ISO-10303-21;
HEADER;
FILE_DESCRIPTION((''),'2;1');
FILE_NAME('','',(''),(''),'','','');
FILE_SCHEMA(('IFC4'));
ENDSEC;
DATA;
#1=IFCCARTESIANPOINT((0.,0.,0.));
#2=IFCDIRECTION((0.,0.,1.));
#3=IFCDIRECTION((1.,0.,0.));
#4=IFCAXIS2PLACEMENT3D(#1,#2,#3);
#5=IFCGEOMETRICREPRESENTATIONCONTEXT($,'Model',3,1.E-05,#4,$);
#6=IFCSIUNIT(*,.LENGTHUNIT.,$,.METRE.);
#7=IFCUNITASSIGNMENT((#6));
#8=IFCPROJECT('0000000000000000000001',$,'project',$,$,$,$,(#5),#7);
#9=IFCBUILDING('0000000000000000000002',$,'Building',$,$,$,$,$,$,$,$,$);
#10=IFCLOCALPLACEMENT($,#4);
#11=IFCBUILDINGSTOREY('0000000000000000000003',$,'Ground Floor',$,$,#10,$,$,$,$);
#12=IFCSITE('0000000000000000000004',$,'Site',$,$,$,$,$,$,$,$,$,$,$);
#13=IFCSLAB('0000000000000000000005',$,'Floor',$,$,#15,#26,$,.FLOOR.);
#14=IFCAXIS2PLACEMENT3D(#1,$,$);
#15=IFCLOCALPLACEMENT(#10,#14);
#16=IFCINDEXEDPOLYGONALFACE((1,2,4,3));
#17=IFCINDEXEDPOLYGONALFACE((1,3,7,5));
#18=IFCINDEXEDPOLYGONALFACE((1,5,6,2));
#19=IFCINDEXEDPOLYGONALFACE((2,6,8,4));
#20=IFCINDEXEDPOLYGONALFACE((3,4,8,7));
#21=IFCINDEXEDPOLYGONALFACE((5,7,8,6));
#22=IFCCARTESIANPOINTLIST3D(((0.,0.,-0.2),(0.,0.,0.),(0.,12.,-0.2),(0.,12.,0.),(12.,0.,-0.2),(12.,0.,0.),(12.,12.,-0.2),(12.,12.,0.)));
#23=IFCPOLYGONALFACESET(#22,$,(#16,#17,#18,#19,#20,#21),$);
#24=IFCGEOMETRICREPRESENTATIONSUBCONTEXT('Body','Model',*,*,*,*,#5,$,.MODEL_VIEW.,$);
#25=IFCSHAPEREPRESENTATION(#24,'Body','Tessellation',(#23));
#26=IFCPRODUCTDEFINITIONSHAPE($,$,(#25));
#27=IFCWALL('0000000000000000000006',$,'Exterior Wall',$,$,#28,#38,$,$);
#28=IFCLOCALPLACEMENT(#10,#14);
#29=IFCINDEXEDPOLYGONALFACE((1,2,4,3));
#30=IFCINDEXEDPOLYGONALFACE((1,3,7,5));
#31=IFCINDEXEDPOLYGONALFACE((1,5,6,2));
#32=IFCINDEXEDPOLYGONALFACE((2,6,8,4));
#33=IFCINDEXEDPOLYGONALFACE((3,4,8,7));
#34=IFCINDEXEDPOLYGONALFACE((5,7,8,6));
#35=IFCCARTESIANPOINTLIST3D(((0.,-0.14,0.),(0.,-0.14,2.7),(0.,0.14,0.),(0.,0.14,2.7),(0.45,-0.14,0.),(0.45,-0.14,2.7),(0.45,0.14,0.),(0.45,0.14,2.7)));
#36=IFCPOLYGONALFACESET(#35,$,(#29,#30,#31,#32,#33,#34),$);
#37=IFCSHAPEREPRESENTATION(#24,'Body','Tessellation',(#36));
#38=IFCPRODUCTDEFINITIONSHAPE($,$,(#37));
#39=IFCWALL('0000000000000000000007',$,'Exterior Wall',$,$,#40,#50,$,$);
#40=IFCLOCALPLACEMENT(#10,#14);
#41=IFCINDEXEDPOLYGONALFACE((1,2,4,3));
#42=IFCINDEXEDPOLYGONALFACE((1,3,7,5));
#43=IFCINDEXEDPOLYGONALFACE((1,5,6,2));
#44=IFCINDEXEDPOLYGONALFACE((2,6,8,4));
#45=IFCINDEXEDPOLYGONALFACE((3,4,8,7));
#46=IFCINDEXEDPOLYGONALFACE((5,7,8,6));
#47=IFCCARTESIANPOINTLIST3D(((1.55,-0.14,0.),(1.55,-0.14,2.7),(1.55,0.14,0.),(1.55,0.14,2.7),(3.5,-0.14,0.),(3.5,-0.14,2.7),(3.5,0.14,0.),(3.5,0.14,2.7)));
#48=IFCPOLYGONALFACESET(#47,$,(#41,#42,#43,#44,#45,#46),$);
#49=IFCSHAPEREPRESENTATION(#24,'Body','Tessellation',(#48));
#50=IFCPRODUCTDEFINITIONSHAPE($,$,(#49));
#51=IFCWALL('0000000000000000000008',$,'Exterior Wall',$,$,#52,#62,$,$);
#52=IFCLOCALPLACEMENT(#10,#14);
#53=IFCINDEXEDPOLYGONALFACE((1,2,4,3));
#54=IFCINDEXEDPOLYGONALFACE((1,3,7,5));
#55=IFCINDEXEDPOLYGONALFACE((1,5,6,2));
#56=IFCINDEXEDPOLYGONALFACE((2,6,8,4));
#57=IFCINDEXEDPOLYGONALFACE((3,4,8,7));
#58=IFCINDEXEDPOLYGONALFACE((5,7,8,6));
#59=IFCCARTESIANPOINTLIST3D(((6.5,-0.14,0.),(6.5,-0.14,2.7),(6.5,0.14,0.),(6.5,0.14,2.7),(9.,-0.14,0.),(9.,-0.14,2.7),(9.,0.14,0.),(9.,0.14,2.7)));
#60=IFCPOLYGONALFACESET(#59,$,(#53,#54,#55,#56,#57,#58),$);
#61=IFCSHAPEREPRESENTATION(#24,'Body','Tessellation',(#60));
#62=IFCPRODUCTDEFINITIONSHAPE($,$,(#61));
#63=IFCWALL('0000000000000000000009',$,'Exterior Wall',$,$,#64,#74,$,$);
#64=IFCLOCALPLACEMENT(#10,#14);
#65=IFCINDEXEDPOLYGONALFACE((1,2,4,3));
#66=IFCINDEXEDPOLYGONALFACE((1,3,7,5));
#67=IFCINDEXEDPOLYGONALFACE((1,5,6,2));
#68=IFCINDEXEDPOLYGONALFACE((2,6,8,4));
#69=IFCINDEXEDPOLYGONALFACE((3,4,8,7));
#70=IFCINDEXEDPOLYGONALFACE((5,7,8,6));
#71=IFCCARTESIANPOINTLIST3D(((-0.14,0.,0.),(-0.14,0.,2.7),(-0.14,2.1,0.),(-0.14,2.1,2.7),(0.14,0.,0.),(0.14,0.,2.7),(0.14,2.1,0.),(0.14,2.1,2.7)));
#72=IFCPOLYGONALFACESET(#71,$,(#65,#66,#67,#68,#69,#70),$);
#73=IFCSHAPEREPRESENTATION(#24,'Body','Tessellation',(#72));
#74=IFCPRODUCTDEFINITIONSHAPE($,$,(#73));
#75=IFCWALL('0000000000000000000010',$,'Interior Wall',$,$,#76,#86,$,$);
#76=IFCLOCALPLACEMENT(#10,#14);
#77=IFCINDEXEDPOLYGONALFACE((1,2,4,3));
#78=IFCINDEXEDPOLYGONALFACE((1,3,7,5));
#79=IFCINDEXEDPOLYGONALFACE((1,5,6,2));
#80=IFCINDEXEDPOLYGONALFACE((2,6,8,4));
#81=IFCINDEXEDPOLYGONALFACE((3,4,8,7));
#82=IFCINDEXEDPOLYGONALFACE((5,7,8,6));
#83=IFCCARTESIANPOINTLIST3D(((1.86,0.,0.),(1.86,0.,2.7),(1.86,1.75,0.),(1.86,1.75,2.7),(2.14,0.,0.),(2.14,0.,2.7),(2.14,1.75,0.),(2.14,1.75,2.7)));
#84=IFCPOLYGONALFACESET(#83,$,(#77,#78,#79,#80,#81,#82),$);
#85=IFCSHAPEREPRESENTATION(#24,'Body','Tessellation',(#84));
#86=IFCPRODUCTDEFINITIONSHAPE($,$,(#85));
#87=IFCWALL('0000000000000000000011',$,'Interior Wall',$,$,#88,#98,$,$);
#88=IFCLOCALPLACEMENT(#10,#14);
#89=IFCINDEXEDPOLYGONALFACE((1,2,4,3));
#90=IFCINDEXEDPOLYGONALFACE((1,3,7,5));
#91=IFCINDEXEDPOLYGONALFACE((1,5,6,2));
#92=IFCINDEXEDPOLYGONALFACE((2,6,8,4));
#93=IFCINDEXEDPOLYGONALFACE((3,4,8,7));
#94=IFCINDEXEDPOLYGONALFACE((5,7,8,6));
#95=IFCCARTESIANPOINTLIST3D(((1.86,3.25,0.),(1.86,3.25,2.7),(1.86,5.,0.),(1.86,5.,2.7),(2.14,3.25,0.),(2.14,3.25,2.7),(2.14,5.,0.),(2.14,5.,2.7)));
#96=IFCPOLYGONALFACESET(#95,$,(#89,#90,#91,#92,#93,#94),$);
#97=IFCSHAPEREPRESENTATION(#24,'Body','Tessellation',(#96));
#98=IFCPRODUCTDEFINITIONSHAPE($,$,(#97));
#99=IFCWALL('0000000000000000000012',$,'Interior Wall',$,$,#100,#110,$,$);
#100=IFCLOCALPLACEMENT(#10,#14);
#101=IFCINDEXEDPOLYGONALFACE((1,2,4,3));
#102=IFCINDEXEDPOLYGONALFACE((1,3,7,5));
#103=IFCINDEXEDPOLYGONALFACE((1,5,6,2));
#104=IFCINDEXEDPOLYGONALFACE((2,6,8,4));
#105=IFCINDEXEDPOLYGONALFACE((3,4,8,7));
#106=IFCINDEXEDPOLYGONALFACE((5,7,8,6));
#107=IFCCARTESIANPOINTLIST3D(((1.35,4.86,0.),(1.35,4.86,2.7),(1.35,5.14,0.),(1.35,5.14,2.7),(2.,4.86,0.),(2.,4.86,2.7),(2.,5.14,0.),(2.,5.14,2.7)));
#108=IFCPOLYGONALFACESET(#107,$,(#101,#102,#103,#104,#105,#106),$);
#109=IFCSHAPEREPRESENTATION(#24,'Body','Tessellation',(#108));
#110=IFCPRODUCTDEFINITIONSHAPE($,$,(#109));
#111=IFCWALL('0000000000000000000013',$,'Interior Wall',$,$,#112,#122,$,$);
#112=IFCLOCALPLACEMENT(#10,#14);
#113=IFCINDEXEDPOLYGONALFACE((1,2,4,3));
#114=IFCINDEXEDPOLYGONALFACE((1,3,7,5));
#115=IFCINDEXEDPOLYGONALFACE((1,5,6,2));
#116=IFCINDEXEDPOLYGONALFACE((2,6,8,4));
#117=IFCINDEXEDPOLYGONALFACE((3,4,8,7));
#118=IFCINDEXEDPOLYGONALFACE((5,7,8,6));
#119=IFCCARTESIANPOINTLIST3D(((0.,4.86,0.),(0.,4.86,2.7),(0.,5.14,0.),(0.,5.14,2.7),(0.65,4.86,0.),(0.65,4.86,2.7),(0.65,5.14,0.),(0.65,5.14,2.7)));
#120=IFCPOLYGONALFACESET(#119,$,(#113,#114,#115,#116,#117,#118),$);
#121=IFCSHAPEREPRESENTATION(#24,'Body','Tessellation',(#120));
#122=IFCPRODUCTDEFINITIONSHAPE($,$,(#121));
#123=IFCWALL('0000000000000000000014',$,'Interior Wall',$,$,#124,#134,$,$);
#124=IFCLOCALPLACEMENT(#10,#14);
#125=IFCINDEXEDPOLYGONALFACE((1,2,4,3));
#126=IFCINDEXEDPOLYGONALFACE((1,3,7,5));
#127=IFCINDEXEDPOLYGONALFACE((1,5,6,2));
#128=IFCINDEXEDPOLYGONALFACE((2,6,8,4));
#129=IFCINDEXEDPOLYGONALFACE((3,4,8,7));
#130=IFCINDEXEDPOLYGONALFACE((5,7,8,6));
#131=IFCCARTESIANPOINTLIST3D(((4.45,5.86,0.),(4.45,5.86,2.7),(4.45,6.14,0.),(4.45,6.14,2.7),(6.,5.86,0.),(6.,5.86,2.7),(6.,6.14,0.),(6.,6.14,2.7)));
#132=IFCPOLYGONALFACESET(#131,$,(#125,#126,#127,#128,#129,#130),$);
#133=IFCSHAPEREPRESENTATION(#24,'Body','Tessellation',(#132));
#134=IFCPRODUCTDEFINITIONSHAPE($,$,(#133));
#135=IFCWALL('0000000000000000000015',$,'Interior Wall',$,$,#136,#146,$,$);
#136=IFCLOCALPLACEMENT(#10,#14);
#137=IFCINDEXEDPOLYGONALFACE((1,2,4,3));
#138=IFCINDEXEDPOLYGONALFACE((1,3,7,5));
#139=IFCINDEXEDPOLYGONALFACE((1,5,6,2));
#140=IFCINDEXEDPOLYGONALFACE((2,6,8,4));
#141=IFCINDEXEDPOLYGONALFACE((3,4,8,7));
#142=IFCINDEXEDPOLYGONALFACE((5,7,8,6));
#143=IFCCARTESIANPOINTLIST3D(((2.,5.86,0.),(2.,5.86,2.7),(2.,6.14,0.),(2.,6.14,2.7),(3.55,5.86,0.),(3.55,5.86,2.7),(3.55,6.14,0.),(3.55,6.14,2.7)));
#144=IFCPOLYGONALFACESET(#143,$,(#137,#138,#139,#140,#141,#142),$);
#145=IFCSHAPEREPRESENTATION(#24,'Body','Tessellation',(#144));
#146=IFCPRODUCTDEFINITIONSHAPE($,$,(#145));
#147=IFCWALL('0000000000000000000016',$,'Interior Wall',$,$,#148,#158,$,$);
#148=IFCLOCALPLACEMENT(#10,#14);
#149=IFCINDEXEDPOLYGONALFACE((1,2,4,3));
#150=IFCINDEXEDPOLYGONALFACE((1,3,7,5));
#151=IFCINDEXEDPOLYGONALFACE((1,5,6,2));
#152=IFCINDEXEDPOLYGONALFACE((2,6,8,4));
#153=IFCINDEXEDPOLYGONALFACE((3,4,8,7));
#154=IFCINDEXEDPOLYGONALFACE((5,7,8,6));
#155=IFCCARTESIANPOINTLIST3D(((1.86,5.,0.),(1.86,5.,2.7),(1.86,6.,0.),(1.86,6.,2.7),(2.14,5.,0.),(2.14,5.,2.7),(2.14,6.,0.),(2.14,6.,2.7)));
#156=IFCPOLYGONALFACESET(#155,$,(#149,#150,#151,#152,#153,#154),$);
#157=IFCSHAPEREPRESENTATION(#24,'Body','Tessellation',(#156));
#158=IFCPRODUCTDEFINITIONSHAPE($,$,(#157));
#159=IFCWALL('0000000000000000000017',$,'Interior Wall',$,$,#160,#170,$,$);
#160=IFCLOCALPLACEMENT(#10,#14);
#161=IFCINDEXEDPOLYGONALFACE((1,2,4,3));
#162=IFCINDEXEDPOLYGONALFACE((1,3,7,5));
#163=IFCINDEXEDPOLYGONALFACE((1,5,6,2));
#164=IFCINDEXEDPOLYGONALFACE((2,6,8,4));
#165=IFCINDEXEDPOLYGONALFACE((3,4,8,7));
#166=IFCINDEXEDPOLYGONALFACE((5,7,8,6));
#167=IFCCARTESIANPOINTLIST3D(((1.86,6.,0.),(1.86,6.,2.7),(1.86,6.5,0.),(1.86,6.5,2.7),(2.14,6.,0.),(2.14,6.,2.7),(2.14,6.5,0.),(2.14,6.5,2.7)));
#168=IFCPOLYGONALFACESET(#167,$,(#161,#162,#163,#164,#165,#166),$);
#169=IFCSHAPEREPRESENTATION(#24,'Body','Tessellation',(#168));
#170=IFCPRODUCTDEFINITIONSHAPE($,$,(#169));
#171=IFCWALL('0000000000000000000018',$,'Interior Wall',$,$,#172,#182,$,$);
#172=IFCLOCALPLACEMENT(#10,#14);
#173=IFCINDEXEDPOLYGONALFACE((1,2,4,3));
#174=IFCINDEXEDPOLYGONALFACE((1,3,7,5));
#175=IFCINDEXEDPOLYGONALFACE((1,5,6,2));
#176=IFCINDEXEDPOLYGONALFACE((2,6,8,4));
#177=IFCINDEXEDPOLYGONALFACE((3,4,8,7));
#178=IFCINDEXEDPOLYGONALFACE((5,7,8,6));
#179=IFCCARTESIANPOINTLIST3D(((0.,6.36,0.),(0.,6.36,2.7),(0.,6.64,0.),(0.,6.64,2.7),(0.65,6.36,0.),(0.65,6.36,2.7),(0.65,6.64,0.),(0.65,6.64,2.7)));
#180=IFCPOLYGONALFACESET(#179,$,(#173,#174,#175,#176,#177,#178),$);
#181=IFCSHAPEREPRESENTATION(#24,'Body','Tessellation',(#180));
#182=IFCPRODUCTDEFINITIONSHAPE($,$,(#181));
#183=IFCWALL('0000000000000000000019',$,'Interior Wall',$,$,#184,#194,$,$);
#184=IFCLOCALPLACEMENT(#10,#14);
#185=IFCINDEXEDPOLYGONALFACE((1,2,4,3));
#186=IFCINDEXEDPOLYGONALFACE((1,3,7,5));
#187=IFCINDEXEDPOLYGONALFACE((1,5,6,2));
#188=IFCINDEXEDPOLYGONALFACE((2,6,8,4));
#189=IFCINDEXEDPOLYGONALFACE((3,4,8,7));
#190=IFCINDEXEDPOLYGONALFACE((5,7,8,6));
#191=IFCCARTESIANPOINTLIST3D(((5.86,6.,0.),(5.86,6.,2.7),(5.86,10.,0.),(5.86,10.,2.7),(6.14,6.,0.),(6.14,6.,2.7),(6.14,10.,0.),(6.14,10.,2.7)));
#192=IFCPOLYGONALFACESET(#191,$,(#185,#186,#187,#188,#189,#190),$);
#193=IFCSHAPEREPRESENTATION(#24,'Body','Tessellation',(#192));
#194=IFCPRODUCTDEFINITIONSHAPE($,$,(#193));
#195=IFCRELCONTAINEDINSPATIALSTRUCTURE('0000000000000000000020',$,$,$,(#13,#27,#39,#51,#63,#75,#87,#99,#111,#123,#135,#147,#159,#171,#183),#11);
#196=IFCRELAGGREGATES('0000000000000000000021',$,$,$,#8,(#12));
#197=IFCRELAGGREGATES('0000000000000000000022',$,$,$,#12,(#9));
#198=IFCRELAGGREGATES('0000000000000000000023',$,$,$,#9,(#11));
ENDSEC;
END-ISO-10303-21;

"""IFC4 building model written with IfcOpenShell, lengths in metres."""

from ifc_helpers import new_model, si_unit, frame, origin_with_axes, place, context, subcontext, project, spatial, indexed_curve, outline, extrude, element, save


model = new_model("IFC4")

# Units and contexts
model_context = context("Model", 3, precision=1e-05, world=origin_with_axes())
body_context = subcontext(model_context, "Body", "Model", "MODEL_VIEW")
ifc_project = project(units=[si_unit("LENGTHUNIT", "METRE")], contexts=[model_context])

# Site, building, storey
site = spatial("IfcSite", under=ifc_project, Name="Site")
building = spatial("IfcBuilding", under=site, Name="Building")
storey_placement = place(None, origin_with_axes())
storey = spatial("IfcBuildingStorey", under=building, at=storey_placement, Name="Ground Floor")

# Slab
slab_placement = place(storey_placement, frame((0.0, 0.0, -0.2), z_axis=(0.0, 0.0, 1.0), x_axis=(1.0, 0.0, 0.0)))
element("IfcSlab", 1, at=slab_placement, inside=storey, Name="Floor", PredefinedType="FLOOR", context=body_context, shape_type="SweptSolid", body=[
    extrude(outline(indexed_curve([(0.0, 0.0), (12.0, 0.0), (12.0, 12.0), (0.0, 12.0)])), None, (0.0, 0.0, 1.0), 0.2),
])

# Walls
wall_1_placement = place(storey_placement, origin_with_axes())
element("IfcWall", 2, at=wall_1_placement, inside=storey, Name="Exterior Wall", context=body_context, shape_type="SweptSolid", body=[
    extrude(outline(indexed_curve([(0.0, 0.0), (0.0, 0.28), (0.45, 0.28), (0.45, 0.0), (0.0, 0.0)], self_intersect=False)), frame((0.0, -0.14, 0.0), z_axis=(0.0, 0.0, 1.0), x_axis=(1.0, 0.0, 0.0)), (0.0, 0.0, 1.0), 2.7),
])
wall_2_placement = place(storey_placement, frame((1.55, 0.0, 0.0), z_axis=(0.0, 0.0, 1.0), x_axis=(1.0, 0.0, 0.0)))
element("IfcWall", 3, at=wall_2_placement, inside=storey, Name="Exterior Wall", context=body_context, shape_type="SweptSolid", body=[
    extrude(outline(indexed_curve([(0.0, 0.0), (0.0, 0.28), (1.95, 0.28), (1.95, 0.0), (0.0, 0.0)], self_intersect=False)), frame((0.0, -0.14, 0.0), z_axis=(0.0, 0.0, 1.0), x_axis=(1.0, 0.0, 0.0)), (0.0, 0.0, 1.0), 2.7),
])
wall_3_placement = place(storey_placement, frame((6.5, 0.0, 0.0), z_axis=(0.0, 0.0, 1.0), x_axis=(1.0, 0.0, 0.0)))
element("IfcWall", 4, at=wall_3_placement, inside=storey, Name="Exterior Wall", context=body_context, shape_type="SweptSolid", body=[
    extrude(outline(indexed_curve([(0.0, 0.0), (0.0, 0.28), (2.5, 0.28), (2.5, 0.0), (0.0, 0.0)], self_intersect=False)), frame((0.0, -0.14, 0.0), z_axis=(0.0, 0.0, 1.0), x_axis=(1.0, 0.0, 0.0)), (0.0, 0.0, 1.0), 2.7),
])
wall_4_placement = place(storey_placement, frame((0.0, 2.1, 0.0), z_axis=(0.0, 0.0, 1.0), x_axis=(0.0, -1.0, 0.0)))
element("IfcWall", 5, at=wall_4_placement, inside=storey, Name="Exterior Wall", context=body_context, shape_type="SweptSolid", body=[
    extrude(outline(indexed_curve([(0.0, 0.0), (0.0, 0.28), (2.1, 0.28), (2.1, 0.0), (0.0, 0.0)], self_intersect=False)), frame((0.0, -0.14, 0.0), z_axis=(0.0, 0.0, 1.0), x_axis=(1.0, 0.0, 0.0)), (0.0, 0.0, 1.0), 2.7),
])
for number, where, z_axis, x_axis, name in (
    (6, (2.0, 0.0, 0.0), (0.0, 0.0, 1.0), (0.0, 1.0, 0.0), "Interior Wall"),
    (7, (2.0, 3.25, 0.0), (0.0, 0.0, 1.0), (0.0, 1.0, 0.0), "Interior Wall"),
):
    element("IfcWall", number, at=place(storey_placement, frame(where, z_axis=z_axis, x_axis=x_axis)), inside=storey, Name=name, context=body_context, shape_type="SweptSolid", body=[
        extrude(outline(indexed_curve([(0.0, 0.0), (0.0, 0.28), (1.75, 0.28), (1.75, 0.0), (0.0, 0.0)], self_intersect=False)), frame((0.0, -0.14, 0.0), z_axis=(0.0, 0.0, 1.0), x_axis=(1.0, 0.0, 0.0)), (0.0, 0.0, 1.0), 2.7),
    ])
for number, where, z_axis, x_axis, name in (
    (8, (2.0, 5.0, 0.0), (0.0, 0.0, 1.0), (-1.0, 0.0, 0.0), "Interior Wall"),
    (9, (0.65, 5.0, 0.0), (0.0, 0.0, 1.0), (-1.0, 0.0, 0.0), "Interior Wall"),
):
    element("IfcWall", number, at=place(storey_placement, frame(where, z_axis=z_axis, x_axis=x_axis)), inside=storey, Name=name, context=body_context, shape_type="SweptSolid", body=[
        extrude(outline(indexed_curve([(0.0, 0.0), (0.0, 0.28), (0.65, 0.28), (0.65, 0.0), (0.0, 0.0)], self_intersect=False)), frame((0.0, -0.14, 0.0), z_axis=(0.0, 0.0, 1.0), x_axis=(1.0, 0.0, 0.0)), (0.0, 0.0, 1.0), 2.7),
    ])
for number, where, z_axis, x_axis, name in (
    (10, (6.0, 6.0, 0.0), (0.0, 0.0, 1.0), (-1.0, 0.0, 0.0), "Interior Wall"),
    (11, (3.55, 6.0, 0.0), (0.0, 0.0, 1.0), (-1.0, 0.0, 0.0), "Interior Wall"),
):
    element("IfcWall", number, at=place(storey_placement, frame(where, z_axis=z_axis, x_axis=x_axis)), inside=storey, Name=name, context=body_context, shape_type="SweptSolid", body=[
        extrude(outline(indexed_curve([(0.0, 0.0), (0.0, 0.28), (1.55, 0.28), (1.55, 0.0), (0.0, 0.0)], self_intersect=False)), frame((0.0, -0.14, 0.0), z_axis=(0.0, 0.0, 1.0), x_axis=(1.0, 0.0, 0.0)), (0.0, 0.0, 1.0), 2.7),
    ])
wall_5_placement = place(storey_placement, frame((2.0, 6.0, 0.0), z_axis=(0.0, 0.0, 1.0), x_axis=(0.0, -1.0, 0.0)))
element("IfcWall", 12, at=wall_5_placement, inside=storey, Name="Interior Wall", context=body_context, shape_type="SweptSolid", body=[
    extrude(outline(indexed_curve([(0.0, 0.0), (0.0, 0.28), (1.0, 0.28), (1.0, 0.0), (0.0, 0.0)], self_intersect=False)), frame((0.0, -0.14, 0.0), z_axis=(0.0, 0.0, 1.0), x_axis=(1.0, 0.0, 0.0)), (0.0, 0.0, 1.0), 2.7),
])
wall_6_placement = place(storey_placement, frame((2.0, 6.0, 0.0), z_axis=(0.0, 0.0, 1.0), x_axis=(0.0, 1.0, 0.0)))
element("IfcWall", 13, at=wall_6_placement, inside=storey, Name="Interior Wall", context=body_context, shape_type="SweptSolid", body=[
    extrude(outline(indexed_curve([(0.0, 0.0), (0.0, 0.28), (0.5, 0.28), (0.5, 0.0), (0.0, 0.0)], self_intersect=False)), frame((0.0, -0.14, 0.0), z_axis=(0.0, 0.0, 1.0), x_axis=(1.0, 0.0, 0.0)), (0.0, 0.0, 1.0), 2.7),
])
wall_7_placement = place(storey_placement, frame((0.65, 6.5, 0.0), z_axis=(0.0, 0.0, 1.0), x_axis=(-1.0, 0.0, 0.0)))
element("IfcWall", 14, at=wall_7_placement, inside=storey, Name="Interior Wall", context=body_context, shape_type="SweptSolid", body=[
    extrude(outline(indexed_curve([(0.0, 0.0), (0.0, 0.28), (0.65, 0.28), (0.65, 0.0), (0.0, 0.0)], self_intersect=False)), frame((0.0, -0.14, 0.0), z_axis=(0.0, 0.0, 1.0), x_axis=(1.0, 0.0, 0.0)), (0.0, 0.0, 1.0), 2.7),
])
wall_8_placement = place(storey_placement, frame((6.0, 6.0, 0.0), z_axis=(0.0, 0.0, 1.0), x_axis=(0.0, 1.0, 0.0)))
element("IfcWall", 15, at=wall_8_placement, inside=storey, Name="Interior Wall", context=body_context, shape_type="SweptSolid", body=[
    extrude(outline(indexed_curve([(0.0, 0.0), (0.0, 0.28), (4.0, 0.28), (4.0, 0.0), (0.0, 0.0)], self_intersect=False)), frame((0.0, -0.14, 0.0), z_axis=(0.0, 0.0, 1.0), x_axis=(1.0, 0.0, 0.0)), (0.0, 0.0, 1.0), 2.7),
])

save(model, "model.ifc")
